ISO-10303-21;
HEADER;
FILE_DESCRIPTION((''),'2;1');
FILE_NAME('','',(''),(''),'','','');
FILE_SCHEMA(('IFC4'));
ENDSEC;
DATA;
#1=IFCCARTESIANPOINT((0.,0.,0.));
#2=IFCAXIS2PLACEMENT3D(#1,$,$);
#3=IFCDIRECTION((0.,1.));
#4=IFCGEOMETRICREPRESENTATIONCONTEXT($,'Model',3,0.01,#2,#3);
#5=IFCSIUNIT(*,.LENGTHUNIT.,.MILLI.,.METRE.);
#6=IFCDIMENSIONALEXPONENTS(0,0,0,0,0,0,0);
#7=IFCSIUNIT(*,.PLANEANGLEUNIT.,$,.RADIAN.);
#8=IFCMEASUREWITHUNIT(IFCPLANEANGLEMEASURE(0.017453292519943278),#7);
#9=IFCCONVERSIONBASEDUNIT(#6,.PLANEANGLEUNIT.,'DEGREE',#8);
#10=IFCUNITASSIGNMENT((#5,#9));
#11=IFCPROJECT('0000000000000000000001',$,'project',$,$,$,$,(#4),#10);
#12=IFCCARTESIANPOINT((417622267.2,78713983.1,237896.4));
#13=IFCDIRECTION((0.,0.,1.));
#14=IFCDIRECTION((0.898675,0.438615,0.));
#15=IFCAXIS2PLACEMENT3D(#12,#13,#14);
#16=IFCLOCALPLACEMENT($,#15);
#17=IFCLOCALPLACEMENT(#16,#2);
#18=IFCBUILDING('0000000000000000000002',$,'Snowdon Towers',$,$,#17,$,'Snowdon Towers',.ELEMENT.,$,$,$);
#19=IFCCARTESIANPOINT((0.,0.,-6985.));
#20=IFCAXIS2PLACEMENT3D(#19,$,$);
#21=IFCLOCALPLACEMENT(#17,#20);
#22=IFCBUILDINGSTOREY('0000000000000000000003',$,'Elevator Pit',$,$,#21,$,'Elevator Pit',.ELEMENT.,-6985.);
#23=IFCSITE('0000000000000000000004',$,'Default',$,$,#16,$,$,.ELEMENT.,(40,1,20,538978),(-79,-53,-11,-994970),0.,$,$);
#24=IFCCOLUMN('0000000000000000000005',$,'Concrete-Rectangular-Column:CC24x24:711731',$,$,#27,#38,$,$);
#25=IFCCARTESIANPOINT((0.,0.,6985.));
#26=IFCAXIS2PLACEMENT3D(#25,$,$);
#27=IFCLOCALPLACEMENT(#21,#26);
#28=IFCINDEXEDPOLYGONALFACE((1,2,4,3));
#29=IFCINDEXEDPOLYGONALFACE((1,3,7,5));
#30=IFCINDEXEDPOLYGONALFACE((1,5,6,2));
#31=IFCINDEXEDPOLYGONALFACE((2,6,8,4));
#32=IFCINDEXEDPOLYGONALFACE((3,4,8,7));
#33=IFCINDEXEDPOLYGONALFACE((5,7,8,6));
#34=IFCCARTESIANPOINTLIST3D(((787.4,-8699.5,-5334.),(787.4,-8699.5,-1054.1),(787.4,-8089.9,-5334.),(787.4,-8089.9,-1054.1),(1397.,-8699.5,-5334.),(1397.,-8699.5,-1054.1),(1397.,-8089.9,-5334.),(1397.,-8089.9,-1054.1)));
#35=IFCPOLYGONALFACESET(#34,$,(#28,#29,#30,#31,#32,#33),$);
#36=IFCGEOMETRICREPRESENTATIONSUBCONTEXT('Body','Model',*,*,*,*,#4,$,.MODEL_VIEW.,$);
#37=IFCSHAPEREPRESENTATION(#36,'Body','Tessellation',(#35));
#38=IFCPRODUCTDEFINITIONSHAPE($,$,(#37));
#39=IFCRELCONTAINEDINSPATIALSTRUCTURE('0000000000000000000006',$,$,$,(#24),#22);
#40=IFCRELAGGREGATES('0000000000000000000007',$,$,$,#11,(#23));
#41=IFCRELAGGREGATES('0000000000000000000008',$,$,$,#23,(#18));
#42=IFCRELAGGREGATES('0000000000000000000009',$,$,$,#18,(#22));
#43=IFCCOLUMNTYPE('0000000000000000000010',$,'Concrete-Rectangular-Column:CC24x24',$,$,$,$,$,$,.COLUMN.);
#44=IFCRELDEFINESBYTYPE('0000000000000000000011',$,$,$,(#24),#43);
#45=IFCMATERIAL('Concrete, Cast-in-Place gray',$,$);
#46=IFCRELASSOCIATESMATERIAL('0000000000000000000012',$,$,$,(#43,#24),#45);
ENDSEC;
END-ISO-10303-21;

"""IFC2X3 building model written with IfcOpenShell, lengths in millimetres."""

from ifc_helpers import new_model, entity, si_unit, converted_unit, direction, frame, origin, origin_2d_with_axis, place, context, subcontext, project, spatial, rectangle, extrude, source, transform, mapped, material, type_object, type_shapes, element, save


model = new_model("IFC2X3")

# Units and contexts
model_context = context("Model", 3, precision=0.01, world=origin(), true_north=direction((0.0, 1.0)))
body_context = subcontext(model_context, "Body", "Model", "MODEL_VIEW")
ifc_project = project(units=[si_unit("LENGTHUNIT", "METRE", prefix="MILLI"), converted_unit("PLANEANGLEUNIT", "DEGREE", entity("IfcPlaneAngleMeasure", 0.017453292519943278), si_unit("PLANEANGLEUNIT", "RADIAN"), dimensions=[0, 0, 0, 0, 0, 0, 0])], contexts=[model_context])

# Site, building, storey
site_placement = place(None, frame((417622267.2, 78713983.1, 237896.4), z_axis=(0.0, 0.0, 1.0), x_axis=(0.898675, 0.438615, 0.0)))
site = spatial("IfcSite", under=ifc_project, at=site_placement, Name="Default", CompositionType="ELEMENT", RefLatitude=(40, 1, 20, 538978), RefLongitude=(-79, -53, -11, -994970), RefElevation=0.0)
building_placement = place(site_placement, origin())
building = spatial("IfcBuilding", under=site, at=building_placement, Name="Snowdon Towers", LongName="Snowdon Towers", CompositionType="ELEMENT")
storey_placement = place(building_placement, frame((0.0, 0.0, -6985.0)))
storey = spatial("IfcBuildingStorey", under=building, at=storey_placement, Name="Elevator Pit", LongName="Elevator Pit", CompositionType="ELEMENT", Elevation=-6985.0)

# Shared definitions
ifc_material = material(Name="Concrete, Cast-in-Place gray")

# Column
column_type_1 = type_object("IfcColumnType", Name="Concrete-Rectangular-Column:CC24x24", PredefinedType="COLUMN", material=ifc_material)
shared_shape_1 = source(origin(), body_context, "Body", "SweptSolid", [
    extrude(rectangle(XDim=609.6, YDim=609.6, at=origin_2d_with_axis()), frame((1092.2, -8394.7, -5334.0), z_axis=(0.0, 0.0, 1.0), x_axis=(-1.0, 0.0, 0.0)), (0.0, 0.0, 1.0), 4279.9),
])
type_shapes(column_type_1, [shared_shape_1])
column_1_placement = place(storey_placement, frame((0.0, 0.0, 6985.0)))
element("IfcColumn", 1, at=column_1_placement, inside=storey, type_object=column_type_1, material=ifc_material, Name="Concrete-Rectangular-Column:CC24x24:711731", context=body_context, shape_type="MappedRepresentation", body=[
    mapped(shared_shape_1, transform((0.0, 0.0, 0.0), scale=1.0)),
])

save(model, "model.ifc")
